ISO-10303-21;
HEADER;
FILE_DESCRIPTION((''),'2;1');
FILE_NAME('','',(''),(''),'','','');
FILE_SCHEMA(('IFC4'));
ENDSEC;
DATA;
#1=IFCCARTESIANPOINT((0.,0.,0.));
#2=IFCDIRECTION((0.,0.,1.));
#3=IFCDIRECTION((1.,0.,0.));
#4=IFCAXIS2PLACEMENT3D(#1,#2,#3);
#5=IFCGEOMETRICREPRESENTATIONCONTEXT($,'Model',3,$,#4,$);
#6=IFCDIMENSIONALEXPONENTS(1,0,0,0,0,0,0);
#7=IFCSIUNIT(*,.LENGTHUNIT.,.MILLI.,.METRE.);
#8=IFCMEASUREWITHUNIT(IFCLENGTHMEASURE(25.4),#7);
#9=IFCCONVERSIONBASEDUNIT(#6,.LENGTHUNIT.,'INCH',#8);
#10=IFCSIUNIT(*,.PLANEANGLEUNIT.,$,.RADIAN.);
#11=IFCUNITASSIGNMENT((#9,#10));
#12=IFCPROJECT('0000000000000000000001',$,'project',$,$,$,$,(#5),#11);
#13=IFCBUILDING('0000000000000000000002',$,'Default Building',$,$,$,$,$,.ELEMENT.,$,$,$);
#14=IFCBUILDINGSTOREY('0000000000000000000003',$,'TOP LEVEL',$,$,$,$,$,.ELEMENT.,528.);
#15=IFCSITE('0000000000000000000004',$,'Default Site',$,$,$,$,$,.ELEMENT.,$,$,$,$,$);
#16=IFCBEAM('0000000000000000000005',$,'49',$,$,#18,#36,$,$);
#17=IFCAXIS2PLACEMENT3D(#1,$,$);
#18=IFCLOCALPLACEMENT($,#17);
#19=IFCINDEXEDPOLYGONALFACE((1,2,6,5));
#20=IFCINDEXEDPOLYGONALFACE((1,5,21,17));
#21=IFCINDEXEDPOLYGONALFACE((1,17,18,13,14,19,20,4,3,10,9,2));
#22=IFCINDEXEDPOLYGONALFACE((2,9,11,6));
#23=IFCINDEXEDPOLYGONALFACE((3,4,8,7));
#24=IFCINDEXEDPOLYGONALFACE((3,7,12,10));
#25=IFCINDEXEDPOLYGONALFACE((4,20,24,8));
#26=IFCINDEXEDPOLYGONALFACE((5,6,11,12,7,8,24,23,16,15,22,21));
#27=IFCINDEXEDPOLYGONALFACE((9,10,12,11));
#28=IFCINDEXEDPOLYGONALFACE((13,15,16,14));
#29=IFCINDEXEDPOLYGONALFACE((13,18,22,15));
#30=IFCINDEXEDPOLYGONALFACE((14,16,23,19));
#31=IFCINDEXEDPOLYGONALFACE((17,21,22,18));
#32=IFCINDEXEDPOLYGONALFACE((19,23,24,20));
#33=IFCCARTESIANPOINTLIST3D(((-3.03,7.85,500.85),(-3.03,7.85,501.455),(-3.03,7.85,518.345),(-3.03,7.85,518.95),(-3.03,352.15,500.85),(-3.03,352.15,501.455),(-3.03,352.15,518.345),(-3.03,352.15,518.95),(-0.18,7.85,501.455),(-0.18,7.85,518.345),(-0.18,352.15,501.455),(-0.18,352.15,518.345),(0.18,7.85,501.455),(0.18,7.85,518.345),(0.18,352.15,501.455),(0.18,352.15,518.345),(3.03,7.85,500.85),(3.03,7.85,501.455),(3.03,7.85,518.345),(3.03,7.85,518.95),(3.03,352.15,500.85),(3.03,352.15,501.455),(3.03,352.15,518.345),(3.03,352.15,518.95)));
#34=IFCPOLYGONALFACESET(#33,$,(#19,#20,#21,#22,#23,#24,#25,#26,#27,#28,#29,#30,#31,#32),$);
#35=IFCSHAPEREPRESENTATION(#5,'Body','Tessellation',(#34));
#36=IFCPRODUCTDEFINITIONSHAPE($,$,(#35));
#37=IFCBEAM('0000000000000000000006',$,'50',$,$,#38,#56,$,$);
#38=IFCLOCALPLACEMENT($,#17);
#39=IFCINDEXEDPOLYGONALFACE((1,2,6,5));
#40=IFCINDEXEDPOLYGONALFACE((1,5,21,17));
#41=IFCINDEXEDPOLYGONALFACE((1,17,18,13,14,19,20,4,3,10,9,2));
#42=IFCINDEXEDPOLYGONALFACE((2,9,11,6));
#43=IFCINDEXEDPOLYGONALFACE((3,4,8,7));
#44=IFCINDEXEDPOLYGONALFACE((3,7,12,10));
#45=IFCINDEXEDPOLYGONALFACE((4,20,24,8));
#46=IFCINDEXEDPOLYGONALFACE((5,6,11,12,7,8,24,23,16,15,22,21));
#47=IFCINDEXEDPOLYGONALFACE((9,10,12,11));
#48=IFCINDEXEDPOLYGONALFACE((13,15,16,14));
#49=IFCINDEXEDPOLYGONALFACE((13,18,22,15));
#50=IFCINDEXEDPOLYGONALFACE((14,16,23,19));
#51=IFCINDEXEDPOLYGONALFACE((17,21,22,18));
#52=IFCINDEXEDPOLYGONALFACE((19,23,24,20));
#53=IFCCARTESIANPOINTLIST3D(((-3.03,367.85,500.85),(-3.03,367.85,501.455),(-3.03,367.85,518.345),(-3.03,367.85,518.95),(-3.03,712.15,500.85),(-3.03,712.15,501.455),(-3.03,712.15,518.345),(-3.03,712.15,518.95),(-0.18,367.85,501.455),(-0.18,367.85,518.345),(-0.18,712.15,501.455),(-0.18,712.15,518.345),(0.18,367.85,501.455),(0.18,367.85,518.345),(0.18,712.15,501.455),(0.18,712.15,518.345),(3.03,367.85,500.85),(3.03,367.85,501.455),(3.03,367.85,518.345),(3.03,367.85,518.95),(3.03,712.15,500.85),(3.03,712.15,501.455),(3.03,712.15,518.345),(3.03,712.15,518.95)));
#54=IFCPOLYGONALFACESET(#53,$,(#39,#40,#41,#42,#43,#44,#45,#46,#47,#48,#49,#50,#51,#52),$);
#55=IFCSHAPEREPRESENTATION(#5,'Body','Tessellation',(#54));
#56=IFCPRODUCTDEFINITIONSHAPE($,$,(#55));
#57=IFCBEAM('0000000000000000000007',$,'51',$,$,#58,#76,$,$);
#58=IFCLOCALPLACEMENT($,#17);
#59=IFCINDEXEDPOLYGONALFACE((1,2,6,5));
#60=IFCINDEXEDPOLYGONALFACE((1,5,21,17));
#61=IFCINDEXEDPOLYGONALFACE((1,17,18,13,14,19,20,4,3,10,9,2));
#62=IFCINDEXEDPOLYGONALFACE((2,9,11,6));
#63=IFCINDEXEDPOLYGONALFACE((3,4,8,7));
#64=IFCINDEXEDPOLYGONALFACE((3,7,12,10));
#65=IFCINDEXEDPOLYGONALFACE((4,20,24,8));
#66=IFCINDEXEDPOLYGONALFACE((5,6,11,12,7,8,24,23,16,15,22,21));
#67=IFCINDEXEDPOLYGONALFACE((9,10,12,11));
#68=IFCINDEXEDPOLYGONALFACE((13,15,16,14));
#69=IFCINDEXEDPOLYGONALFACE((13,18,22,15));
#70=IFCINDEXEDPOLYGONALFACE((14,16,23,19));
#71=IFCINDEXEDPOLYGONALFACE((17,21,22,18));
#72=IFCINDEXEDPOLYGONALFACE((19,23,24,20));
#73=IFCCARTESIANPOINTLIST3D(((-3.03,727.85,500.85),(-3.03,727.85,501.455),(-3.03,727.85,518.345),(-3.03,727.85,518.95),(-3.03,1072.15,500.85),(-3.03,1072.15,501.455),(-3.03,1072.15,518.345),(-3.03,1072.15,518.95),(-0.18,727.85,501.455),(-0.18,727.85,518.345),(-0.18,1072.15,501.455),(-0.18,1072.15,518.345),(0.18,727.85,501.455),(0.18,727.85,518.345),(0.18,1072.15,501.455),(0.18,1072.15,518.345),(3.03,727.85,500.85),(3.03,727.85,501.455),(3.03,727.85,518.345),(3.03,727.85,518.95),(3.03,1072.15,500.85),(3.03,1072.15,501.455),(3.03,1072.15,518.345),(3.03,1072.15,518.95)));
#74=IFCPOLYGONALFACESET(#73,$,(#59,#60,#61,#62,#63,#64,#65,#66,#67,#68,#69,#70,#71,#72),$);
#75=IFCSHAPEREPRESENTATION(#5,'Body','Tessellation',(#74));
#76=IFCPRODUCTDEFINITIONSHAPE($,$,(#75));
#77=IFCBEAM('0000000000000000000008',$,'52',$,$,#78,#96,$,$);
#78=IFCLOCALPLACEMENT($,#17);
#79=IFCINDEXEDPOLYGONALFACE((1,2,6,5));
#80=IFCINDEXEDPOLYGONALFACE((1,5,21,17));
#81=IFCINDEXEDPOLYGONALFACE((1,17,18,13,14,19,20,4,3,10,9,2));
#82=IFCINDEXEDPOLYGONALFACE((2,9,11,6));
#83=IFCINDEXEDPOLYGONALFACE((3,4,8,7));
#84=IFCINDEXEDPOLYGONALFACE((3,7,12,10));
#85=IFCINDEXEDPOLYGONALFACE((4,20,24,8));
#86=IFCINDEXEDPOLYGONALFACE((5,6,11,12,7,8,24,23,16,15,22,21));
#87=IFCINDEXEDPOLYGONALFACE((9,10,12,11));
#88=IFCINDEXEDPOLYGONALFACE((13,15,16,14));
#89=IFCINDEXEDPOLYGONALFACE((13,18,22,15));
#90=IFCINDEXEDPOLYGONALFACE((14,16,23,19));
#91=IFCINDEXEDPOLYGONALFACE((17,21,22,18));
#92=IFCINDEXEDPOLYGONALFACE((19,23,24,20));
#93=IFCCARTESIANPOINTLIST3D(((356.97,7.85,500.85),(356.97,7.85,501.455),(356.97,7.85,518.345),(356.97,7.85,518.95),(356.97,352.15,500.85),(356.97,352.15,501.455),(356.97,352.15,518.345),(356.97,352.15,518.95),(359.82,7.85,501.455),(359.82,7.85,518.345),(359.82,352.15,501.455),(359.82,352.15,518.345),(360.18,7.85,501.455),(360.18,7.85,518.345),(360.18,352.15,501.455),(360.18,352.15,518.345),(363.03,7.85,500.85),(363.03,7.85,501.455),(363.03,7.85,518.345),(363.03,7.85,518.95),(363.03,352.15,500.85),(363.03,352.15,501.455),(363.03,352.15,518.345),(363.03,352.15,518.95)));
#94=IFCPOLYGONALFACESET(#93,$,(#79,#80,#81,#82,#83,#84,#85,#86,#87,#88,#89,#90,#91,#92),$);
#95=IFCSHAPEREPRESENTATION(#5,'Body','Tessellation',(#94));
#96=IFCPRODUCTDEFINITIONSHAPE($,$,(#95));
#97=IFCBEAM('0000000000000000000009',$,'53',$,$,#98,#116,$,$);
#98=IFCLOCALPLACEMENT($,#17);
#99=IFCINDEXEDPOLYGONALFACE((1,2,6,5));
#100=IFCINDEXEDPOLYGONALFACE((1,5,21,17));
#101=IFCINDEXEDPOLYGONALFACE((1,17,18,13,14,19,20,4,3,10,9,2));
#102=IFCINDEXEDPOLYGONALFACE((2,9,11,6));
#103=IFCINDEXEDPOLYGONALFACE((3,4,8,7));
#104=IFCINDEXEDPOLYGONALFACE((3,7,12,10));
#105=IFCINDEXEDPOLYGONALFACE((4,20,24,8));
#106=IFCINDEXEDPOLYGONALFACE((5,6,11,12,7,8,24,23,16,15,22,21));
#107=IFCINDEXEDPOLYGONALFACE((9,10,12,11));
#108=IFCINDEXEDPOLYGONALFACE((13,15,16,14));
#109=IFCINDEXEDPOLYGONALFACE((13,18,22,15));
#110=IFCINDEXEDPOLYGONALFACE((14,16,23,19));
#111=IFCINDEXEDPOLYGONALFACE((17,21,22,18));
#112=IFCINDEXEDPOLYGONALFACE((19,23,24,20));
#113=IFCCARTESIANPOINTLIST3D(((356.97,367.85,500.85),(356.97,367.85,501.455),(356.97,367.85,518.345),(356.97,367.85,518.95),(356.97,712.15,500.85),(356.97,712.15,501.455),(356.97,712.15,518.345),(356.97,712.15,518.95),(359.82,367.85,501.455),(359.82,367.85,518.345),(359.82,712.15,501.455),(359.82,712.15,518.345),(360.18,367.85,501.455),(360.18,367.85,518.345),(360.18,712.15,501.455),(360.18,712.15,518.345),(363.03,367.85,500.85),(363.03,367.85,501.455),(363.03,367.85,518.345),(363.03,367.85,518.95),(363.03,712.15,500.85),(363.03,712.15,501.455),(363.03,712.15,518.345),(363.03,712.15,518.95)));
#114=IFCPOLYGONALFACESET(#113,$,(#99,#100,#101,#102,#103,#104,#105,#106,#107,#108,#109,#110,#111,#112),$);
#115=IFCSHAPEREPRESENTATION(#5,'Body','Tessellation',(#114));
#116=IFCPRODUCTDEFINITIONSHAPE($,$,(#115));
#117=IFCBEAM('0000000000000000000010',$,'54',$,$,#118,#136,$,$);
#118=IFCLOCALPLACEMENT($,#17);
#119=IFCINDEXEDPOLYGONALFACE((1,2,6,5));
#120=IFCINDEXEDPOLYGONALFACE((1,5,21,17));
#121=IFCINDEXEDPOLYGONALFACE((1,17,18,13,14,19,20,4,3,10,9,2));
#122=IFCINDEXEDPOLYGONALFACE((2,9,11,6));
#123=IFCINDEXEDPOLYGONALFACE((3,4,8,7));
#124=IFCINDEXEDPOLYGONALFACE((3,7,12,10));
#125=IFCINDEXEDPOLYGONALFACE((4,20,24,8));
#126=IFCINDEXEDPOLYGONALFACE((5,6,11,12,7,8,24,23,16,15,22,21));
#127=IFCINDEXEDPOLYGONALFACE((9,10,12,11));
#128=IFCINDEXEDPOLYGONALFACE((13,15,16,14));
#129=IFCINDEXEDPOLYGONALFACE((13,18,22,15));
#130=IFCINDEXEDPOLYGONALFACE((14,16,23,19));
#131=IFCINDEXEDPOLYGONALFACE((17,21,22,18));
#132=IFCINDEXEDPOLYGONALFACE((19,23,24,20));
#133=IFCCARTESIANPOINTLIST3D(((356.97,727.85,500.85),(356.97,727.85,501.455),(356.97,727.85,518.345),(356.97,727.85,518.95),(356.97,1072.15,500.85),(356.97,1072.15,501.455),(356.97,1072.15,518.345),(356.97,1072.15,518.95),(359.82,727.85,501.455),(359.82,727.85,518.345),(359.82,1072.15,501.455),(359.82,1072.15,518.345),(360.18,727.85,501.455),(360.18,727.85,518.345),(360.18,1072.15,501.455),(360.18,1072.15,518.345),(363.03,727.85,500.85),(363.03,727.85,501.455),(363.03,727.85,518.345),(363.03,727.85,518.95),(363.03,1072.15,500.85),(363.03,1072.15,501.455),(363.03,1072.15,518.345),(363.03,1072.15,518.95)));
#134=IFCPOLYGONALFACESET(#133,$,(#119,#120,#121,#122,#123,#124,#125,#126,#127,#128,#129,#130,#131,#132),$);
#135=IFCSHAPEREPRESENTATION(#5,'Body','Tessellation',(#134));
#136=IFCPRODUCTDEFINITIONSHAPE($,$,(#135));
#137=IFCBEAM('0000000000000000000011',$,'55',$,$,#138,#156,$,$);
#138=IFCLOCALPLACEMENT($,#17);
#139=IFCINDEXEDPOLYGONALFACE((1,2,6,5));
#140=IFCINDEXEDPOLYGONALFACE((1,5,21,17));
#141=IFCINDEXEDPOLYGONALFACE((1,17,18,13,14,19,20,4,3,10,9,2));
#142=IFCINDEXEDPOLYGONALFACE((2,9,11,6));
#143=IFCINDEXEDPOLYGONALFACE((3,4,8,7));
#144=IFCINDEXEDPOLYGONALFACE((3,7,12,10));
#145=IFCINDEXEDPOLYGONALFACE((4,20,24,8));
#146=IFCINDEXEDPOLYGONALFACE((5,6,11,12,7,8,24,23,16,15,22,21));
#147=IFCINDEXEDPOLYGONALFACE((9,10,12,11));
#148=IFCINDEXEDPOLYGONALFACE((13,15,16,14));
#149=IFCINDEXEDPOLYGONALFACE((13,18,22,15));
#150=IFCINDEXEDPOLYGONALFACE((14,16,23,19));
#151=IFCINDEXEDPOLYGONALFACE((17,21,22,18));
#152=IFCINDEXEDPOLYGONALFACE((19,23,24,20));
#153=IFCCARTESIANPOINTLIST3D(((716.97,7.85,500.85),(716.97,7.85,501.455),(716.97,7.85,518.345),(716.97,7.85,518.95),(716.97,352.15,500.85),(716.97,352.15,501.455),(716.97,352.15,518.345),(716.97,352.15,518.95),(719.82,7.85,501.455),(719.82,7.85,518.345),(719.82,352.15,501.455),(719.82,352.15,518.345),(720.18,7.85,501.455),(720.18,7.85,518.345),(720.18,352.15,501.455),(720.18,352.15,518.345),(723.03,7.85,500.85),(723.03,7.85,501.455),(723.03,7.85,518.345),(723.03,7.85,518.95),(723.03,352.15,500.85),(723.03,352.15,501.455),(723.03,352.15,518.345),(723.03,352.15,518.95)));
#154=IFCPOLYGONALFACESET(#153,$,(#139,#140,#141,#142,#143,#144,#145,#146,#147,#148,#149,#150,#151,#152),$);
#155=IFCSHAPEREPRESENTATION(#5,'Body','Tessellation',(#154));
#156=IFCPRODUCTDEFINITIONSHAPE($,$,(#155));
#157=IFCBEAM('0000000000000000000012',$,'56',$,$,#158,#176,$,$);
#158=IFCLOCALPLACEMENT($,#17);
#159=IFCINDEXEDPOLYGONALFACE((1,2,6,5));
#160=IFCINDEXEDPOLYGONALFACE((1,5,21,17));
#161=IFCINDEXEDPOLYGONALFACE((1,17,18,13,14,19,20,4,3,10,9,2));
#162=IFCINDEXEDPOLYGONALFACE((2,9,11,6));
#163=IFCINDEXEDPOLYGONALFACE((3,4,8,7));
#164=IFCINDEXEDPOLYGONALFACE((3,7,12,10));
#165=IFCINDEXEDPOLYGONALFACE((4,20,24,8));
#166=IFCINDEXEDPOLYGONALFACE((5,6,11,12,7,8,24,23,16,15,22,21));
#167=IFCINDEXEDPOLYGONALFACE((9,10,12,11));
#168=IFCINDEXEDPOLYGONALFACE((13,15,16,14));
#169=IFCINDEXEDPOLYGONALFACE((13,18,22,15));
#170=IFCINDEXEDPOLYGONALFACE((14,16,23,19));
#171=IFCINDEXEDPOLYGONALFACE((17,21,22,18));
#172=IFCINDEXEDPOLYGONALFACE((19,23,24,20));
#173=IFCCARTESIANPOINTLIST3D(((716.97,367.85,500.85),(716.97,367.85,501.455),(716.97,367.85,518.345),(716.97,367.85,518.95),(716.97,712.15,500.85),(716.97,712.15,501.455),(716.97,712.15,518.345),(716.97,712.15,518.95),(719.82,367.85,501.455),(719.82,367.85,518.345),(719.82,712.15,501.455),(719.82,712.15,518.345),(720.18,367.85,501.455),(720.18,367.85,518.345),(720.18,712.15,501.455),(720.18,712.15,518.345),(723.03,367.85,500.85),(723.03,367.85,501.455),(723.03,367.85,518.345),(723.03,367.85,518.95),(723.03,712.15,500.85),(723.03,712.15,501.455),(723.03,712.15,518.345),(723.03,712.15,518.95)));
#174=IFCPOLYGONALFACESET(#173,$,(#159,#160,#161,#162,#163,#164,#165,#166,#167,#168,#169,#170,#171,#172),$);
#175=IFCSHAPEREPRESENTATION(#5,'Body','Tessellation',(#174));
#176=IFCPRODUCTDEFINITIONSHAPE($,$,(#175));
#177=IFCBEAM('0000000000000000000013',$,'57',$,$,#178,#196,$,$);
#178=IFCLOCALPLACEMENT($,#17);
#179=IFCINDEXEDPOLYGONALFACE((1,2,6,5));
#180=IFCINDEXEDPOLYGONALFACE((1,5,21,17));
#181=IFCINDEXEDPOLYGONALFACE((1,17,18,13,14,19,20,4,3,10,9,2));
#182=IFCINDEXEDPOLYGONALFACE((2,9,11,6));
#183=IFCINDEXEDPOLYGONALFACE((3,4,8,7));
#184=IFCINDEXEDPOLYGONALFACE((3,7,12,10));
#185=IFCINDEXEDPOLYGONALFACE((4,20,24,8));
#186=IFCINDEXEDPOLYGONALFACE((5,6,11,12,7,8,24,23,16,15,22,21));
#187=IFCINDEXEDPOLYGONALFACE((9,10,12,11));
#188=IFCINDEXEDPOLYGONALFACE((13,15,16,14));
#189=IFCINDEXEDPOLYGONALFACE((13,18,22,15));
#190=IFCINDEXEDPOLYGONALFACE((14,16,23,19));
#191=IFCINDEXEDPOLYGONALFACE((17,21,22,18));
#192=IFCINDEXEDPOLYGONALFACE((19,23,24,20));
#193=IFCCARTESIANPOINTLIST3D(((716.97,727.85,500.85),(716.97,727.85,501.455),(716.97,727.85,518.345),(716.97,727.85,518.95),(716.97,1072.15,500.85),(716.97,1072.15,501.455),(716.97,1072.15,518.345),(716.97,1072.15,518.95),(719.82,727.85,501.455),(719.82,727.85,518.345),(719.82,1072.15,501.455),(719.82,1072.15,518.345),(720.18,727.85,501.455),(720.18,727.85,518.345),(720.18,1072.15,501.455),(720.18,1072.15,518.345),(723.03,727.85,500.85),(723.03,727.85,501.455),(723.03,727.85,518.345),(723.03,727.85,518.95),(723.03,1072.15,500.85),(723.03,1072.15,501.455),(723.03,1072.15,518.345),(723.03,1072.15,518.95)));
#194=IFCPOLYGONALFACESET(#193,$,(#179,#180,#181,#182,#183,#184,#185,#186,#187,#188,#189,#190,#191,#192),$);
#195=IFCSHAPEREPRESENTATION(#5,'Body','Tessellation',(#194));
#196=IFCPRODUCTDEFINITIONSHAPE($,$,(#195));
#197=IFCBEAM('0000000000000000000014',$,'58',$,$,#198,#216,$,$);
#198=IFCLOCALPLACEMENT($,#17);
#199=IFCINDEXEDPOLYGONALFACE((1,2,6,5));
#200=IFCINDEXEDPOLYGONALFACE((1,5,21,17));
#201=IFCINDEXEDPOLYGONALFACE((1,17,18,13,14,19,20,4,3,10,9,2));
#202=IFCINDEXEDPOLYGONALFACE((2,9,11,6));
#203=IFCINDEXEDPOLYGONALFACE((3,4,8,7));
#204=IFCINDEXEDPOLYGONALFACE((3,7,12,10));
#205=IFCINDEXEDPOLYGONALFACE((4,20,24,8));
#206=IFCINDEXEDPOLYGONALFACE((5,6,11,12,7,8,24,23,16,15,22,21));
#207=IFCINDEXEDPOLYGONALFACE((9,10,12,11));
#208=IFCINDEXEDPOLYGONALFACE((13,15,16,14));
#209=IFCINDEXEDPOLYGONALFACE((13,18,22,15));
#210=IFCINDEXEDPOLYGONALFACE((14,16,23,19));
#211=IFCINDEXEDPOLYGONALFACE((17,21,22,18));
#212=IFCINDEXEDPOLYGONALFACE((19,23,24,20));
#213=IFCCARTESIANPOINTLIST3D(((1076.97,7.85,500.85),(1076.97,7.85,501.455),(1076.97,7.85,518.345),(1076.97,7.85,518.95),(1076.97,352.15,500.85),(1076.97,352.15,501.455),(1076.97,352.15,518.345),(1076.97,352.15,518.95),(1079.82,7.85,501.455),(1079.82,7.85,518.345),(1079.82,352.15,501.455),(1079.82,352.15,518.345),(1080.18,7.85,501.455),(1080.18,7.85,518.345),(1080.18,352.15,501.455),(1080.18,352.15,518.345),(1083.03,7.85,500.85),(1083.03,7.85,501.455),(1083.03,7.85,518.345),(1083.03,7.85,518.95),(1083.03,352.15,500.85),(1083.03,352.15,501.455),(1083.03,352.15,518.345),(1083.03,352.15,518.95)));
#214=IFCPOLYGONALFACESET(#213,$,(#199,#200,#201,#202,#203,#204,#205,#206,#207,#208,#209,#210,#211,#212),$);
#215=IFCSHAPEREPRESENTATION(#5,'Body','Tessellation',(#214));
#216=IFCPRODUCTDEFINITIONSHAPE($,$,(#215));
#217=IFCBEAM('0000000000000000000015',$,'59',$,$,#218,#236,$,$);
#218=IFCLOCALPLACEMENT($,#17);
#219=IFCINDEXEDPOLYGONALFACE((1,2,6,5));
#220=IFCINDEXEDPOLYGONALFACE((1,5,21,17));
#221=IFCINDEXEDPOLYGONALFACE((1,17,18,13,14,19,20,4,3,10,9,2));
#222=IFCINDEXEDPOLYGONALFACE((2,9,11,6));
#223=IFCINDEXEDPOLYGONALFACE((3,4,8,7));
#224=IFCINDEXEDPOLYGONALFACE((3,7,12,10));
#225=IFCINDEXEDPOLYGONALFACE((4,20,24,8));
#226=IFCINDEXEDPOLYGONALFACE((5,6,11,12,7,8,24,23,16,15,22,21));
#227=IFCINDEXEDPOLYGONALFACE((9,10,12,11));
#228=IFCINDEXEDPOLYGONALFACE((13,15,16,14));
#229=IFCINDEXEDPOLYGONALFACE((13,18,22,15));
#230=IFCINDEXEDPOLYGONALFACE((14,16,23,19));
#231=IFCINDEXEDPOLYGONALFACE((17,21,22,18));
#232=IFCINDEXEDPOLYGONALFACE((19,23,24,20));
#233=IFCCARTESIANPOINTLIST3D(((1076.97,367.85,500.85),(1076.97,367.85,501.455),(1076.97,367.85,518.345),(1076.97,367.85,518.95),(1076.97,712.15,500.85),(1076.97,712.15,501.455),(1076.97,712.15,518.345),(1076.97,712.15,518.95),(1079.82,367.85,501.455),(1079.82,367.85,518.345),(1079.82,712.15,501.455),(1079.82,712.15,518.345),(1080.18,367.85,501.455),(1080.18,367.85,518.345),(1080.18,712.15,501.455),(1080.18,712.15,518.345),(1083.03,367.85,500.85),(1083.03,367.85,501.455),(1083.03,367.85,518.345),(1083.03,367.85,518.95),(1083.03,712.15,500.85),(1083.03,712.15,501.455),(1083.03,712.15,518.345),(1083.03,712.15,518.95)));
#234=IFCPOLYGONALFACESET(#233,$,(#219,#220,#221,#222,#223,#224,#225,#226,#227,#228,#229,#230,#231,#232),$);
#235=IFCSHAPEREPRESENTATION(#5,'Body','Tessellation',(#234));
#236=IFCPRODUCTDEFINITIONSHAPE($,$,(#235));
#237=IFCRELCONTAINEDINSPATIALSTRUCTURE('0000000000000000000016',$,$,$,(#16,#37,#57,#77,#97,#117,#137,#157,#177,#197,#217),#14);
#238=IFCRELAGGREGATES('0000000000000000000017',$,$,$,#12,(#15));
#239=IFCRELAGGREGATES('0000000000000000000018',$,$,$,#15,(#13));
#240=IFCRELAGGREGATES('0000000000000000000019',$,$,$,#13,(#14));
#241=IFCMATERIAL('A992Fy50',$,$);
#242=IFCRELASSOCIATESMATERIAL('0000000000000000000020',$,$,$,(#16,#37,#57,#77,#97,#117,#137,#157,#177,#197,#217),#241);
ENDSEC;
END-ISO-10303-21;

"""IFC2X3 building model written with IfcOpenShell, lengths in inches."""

from ifc_helpers import new_model, entity, si_unit, converted_unit, frame, origin_with_axes, origin_2d_with_axis, place, context, project, spatial, i_section, transform_2d, derived_profile, extrude, material, element, save


model = new_model("IFC2X3")

# Units and contexts
model_context = context("Model", 3, world=origin_with_axes())
ifc_project = project(units=[converted_unit("LENGTHUNIT", "INCH", entity("IfcLengthMeasure", 25.4), si_unit("LENGTHUNIT", "METRE", prefix="MILLI"), dimensions=[1, 0, 0, 0, 0, 0, 0]), si_unit("PLANEANGLEUNIT", "RADIAN")], contexts=[model_context])

# Site, building, storey
site = spatial("IfcSite", under=ifc_project, Name="Default Site", CompositionType="ELEMENT")
building = spatial("IfcBuilding", under=site, Name="Default Building", CompositionType="ELEMENT")
storey = spatial("IfcBuildingStorey", under=building, Name="TOP LEVEL", CompositionType="ELEMENT", Elevation=528.0)

# Beams
ifc_material = material(Name="A992Fy50")
for number, where, z_axis, x_axis, name in (
    (1, (0.0, 7.85, 528.0), (0.0, 1.0, 0.0), (-1.0, 0.0, 0.0), "49"),
    (2, (0.0, 367.85, 528.0), (0.0, 1.0, 0.0), (-1.0, 0.0, 0.0), "50"),
    (3, (0.0, 727.85, 528.0), (0.0, 1.0, 0.0), (-1.0, 0.0, 0.0), "51"),
    (4, (360.0, 7.85, 528.0), (0.0, 1.0, 0.0), (-1.0, 0.0, 0.0), "52"),
    (5, (360.0, 367.85, 528.0), (0.0, 1.0, 0.0), (-1.0, 0.0, 0.0), "53"),
    (6, (360.0, 727.85, 528.0), (0.0, 1.0, 0.0), (-1.0, 0.0, 0.0), "54"),
    (7, (720.0, 7.85, 528.0), (0.0, 1.0, 0.0), (-1.0, 0.0, 0.0), "55"),
    (8, (720.0, 367.85, 528.0), (0.0, 1.0, 0.0), (-1.0, 0.0, 0.0), "56"),
    (9, (720.0, 727.85, 528.0), (0.0, 1.0, 0.0), (-1.0, 0.0, 0.0), "57"),
    (10, (1080.0, 7.85, 528.0), (0.0, 1.0, 0.0), (-1.0, 0.0, 0.0), "58"),
    (11, (1080.0, 367.85, 528.0), (0.0, 1.0, 0.0), (-1.0, 0.0, 0.0), "59"),
):
    element("IfcBeam", number, at=place(None, frame(where, z_axis=z_axis, x_axis=x_axis)), inside=storey, material=ifc_material, Name=name, context=model_context, shape_type="SweptSolid", body=[
        extrude(derived_profile(i_section(OverallWidth=6.06, OverallDepth=18.1, WebThickness=0.36, FlangeThickness=0.605, at=origin_2d_with_axis()), transform_2d((0.0, -9.05))), origin_with_axes(), (0.0, 0.0, 1.0), 344.3),
    ])

save(model, "model.ifc")
